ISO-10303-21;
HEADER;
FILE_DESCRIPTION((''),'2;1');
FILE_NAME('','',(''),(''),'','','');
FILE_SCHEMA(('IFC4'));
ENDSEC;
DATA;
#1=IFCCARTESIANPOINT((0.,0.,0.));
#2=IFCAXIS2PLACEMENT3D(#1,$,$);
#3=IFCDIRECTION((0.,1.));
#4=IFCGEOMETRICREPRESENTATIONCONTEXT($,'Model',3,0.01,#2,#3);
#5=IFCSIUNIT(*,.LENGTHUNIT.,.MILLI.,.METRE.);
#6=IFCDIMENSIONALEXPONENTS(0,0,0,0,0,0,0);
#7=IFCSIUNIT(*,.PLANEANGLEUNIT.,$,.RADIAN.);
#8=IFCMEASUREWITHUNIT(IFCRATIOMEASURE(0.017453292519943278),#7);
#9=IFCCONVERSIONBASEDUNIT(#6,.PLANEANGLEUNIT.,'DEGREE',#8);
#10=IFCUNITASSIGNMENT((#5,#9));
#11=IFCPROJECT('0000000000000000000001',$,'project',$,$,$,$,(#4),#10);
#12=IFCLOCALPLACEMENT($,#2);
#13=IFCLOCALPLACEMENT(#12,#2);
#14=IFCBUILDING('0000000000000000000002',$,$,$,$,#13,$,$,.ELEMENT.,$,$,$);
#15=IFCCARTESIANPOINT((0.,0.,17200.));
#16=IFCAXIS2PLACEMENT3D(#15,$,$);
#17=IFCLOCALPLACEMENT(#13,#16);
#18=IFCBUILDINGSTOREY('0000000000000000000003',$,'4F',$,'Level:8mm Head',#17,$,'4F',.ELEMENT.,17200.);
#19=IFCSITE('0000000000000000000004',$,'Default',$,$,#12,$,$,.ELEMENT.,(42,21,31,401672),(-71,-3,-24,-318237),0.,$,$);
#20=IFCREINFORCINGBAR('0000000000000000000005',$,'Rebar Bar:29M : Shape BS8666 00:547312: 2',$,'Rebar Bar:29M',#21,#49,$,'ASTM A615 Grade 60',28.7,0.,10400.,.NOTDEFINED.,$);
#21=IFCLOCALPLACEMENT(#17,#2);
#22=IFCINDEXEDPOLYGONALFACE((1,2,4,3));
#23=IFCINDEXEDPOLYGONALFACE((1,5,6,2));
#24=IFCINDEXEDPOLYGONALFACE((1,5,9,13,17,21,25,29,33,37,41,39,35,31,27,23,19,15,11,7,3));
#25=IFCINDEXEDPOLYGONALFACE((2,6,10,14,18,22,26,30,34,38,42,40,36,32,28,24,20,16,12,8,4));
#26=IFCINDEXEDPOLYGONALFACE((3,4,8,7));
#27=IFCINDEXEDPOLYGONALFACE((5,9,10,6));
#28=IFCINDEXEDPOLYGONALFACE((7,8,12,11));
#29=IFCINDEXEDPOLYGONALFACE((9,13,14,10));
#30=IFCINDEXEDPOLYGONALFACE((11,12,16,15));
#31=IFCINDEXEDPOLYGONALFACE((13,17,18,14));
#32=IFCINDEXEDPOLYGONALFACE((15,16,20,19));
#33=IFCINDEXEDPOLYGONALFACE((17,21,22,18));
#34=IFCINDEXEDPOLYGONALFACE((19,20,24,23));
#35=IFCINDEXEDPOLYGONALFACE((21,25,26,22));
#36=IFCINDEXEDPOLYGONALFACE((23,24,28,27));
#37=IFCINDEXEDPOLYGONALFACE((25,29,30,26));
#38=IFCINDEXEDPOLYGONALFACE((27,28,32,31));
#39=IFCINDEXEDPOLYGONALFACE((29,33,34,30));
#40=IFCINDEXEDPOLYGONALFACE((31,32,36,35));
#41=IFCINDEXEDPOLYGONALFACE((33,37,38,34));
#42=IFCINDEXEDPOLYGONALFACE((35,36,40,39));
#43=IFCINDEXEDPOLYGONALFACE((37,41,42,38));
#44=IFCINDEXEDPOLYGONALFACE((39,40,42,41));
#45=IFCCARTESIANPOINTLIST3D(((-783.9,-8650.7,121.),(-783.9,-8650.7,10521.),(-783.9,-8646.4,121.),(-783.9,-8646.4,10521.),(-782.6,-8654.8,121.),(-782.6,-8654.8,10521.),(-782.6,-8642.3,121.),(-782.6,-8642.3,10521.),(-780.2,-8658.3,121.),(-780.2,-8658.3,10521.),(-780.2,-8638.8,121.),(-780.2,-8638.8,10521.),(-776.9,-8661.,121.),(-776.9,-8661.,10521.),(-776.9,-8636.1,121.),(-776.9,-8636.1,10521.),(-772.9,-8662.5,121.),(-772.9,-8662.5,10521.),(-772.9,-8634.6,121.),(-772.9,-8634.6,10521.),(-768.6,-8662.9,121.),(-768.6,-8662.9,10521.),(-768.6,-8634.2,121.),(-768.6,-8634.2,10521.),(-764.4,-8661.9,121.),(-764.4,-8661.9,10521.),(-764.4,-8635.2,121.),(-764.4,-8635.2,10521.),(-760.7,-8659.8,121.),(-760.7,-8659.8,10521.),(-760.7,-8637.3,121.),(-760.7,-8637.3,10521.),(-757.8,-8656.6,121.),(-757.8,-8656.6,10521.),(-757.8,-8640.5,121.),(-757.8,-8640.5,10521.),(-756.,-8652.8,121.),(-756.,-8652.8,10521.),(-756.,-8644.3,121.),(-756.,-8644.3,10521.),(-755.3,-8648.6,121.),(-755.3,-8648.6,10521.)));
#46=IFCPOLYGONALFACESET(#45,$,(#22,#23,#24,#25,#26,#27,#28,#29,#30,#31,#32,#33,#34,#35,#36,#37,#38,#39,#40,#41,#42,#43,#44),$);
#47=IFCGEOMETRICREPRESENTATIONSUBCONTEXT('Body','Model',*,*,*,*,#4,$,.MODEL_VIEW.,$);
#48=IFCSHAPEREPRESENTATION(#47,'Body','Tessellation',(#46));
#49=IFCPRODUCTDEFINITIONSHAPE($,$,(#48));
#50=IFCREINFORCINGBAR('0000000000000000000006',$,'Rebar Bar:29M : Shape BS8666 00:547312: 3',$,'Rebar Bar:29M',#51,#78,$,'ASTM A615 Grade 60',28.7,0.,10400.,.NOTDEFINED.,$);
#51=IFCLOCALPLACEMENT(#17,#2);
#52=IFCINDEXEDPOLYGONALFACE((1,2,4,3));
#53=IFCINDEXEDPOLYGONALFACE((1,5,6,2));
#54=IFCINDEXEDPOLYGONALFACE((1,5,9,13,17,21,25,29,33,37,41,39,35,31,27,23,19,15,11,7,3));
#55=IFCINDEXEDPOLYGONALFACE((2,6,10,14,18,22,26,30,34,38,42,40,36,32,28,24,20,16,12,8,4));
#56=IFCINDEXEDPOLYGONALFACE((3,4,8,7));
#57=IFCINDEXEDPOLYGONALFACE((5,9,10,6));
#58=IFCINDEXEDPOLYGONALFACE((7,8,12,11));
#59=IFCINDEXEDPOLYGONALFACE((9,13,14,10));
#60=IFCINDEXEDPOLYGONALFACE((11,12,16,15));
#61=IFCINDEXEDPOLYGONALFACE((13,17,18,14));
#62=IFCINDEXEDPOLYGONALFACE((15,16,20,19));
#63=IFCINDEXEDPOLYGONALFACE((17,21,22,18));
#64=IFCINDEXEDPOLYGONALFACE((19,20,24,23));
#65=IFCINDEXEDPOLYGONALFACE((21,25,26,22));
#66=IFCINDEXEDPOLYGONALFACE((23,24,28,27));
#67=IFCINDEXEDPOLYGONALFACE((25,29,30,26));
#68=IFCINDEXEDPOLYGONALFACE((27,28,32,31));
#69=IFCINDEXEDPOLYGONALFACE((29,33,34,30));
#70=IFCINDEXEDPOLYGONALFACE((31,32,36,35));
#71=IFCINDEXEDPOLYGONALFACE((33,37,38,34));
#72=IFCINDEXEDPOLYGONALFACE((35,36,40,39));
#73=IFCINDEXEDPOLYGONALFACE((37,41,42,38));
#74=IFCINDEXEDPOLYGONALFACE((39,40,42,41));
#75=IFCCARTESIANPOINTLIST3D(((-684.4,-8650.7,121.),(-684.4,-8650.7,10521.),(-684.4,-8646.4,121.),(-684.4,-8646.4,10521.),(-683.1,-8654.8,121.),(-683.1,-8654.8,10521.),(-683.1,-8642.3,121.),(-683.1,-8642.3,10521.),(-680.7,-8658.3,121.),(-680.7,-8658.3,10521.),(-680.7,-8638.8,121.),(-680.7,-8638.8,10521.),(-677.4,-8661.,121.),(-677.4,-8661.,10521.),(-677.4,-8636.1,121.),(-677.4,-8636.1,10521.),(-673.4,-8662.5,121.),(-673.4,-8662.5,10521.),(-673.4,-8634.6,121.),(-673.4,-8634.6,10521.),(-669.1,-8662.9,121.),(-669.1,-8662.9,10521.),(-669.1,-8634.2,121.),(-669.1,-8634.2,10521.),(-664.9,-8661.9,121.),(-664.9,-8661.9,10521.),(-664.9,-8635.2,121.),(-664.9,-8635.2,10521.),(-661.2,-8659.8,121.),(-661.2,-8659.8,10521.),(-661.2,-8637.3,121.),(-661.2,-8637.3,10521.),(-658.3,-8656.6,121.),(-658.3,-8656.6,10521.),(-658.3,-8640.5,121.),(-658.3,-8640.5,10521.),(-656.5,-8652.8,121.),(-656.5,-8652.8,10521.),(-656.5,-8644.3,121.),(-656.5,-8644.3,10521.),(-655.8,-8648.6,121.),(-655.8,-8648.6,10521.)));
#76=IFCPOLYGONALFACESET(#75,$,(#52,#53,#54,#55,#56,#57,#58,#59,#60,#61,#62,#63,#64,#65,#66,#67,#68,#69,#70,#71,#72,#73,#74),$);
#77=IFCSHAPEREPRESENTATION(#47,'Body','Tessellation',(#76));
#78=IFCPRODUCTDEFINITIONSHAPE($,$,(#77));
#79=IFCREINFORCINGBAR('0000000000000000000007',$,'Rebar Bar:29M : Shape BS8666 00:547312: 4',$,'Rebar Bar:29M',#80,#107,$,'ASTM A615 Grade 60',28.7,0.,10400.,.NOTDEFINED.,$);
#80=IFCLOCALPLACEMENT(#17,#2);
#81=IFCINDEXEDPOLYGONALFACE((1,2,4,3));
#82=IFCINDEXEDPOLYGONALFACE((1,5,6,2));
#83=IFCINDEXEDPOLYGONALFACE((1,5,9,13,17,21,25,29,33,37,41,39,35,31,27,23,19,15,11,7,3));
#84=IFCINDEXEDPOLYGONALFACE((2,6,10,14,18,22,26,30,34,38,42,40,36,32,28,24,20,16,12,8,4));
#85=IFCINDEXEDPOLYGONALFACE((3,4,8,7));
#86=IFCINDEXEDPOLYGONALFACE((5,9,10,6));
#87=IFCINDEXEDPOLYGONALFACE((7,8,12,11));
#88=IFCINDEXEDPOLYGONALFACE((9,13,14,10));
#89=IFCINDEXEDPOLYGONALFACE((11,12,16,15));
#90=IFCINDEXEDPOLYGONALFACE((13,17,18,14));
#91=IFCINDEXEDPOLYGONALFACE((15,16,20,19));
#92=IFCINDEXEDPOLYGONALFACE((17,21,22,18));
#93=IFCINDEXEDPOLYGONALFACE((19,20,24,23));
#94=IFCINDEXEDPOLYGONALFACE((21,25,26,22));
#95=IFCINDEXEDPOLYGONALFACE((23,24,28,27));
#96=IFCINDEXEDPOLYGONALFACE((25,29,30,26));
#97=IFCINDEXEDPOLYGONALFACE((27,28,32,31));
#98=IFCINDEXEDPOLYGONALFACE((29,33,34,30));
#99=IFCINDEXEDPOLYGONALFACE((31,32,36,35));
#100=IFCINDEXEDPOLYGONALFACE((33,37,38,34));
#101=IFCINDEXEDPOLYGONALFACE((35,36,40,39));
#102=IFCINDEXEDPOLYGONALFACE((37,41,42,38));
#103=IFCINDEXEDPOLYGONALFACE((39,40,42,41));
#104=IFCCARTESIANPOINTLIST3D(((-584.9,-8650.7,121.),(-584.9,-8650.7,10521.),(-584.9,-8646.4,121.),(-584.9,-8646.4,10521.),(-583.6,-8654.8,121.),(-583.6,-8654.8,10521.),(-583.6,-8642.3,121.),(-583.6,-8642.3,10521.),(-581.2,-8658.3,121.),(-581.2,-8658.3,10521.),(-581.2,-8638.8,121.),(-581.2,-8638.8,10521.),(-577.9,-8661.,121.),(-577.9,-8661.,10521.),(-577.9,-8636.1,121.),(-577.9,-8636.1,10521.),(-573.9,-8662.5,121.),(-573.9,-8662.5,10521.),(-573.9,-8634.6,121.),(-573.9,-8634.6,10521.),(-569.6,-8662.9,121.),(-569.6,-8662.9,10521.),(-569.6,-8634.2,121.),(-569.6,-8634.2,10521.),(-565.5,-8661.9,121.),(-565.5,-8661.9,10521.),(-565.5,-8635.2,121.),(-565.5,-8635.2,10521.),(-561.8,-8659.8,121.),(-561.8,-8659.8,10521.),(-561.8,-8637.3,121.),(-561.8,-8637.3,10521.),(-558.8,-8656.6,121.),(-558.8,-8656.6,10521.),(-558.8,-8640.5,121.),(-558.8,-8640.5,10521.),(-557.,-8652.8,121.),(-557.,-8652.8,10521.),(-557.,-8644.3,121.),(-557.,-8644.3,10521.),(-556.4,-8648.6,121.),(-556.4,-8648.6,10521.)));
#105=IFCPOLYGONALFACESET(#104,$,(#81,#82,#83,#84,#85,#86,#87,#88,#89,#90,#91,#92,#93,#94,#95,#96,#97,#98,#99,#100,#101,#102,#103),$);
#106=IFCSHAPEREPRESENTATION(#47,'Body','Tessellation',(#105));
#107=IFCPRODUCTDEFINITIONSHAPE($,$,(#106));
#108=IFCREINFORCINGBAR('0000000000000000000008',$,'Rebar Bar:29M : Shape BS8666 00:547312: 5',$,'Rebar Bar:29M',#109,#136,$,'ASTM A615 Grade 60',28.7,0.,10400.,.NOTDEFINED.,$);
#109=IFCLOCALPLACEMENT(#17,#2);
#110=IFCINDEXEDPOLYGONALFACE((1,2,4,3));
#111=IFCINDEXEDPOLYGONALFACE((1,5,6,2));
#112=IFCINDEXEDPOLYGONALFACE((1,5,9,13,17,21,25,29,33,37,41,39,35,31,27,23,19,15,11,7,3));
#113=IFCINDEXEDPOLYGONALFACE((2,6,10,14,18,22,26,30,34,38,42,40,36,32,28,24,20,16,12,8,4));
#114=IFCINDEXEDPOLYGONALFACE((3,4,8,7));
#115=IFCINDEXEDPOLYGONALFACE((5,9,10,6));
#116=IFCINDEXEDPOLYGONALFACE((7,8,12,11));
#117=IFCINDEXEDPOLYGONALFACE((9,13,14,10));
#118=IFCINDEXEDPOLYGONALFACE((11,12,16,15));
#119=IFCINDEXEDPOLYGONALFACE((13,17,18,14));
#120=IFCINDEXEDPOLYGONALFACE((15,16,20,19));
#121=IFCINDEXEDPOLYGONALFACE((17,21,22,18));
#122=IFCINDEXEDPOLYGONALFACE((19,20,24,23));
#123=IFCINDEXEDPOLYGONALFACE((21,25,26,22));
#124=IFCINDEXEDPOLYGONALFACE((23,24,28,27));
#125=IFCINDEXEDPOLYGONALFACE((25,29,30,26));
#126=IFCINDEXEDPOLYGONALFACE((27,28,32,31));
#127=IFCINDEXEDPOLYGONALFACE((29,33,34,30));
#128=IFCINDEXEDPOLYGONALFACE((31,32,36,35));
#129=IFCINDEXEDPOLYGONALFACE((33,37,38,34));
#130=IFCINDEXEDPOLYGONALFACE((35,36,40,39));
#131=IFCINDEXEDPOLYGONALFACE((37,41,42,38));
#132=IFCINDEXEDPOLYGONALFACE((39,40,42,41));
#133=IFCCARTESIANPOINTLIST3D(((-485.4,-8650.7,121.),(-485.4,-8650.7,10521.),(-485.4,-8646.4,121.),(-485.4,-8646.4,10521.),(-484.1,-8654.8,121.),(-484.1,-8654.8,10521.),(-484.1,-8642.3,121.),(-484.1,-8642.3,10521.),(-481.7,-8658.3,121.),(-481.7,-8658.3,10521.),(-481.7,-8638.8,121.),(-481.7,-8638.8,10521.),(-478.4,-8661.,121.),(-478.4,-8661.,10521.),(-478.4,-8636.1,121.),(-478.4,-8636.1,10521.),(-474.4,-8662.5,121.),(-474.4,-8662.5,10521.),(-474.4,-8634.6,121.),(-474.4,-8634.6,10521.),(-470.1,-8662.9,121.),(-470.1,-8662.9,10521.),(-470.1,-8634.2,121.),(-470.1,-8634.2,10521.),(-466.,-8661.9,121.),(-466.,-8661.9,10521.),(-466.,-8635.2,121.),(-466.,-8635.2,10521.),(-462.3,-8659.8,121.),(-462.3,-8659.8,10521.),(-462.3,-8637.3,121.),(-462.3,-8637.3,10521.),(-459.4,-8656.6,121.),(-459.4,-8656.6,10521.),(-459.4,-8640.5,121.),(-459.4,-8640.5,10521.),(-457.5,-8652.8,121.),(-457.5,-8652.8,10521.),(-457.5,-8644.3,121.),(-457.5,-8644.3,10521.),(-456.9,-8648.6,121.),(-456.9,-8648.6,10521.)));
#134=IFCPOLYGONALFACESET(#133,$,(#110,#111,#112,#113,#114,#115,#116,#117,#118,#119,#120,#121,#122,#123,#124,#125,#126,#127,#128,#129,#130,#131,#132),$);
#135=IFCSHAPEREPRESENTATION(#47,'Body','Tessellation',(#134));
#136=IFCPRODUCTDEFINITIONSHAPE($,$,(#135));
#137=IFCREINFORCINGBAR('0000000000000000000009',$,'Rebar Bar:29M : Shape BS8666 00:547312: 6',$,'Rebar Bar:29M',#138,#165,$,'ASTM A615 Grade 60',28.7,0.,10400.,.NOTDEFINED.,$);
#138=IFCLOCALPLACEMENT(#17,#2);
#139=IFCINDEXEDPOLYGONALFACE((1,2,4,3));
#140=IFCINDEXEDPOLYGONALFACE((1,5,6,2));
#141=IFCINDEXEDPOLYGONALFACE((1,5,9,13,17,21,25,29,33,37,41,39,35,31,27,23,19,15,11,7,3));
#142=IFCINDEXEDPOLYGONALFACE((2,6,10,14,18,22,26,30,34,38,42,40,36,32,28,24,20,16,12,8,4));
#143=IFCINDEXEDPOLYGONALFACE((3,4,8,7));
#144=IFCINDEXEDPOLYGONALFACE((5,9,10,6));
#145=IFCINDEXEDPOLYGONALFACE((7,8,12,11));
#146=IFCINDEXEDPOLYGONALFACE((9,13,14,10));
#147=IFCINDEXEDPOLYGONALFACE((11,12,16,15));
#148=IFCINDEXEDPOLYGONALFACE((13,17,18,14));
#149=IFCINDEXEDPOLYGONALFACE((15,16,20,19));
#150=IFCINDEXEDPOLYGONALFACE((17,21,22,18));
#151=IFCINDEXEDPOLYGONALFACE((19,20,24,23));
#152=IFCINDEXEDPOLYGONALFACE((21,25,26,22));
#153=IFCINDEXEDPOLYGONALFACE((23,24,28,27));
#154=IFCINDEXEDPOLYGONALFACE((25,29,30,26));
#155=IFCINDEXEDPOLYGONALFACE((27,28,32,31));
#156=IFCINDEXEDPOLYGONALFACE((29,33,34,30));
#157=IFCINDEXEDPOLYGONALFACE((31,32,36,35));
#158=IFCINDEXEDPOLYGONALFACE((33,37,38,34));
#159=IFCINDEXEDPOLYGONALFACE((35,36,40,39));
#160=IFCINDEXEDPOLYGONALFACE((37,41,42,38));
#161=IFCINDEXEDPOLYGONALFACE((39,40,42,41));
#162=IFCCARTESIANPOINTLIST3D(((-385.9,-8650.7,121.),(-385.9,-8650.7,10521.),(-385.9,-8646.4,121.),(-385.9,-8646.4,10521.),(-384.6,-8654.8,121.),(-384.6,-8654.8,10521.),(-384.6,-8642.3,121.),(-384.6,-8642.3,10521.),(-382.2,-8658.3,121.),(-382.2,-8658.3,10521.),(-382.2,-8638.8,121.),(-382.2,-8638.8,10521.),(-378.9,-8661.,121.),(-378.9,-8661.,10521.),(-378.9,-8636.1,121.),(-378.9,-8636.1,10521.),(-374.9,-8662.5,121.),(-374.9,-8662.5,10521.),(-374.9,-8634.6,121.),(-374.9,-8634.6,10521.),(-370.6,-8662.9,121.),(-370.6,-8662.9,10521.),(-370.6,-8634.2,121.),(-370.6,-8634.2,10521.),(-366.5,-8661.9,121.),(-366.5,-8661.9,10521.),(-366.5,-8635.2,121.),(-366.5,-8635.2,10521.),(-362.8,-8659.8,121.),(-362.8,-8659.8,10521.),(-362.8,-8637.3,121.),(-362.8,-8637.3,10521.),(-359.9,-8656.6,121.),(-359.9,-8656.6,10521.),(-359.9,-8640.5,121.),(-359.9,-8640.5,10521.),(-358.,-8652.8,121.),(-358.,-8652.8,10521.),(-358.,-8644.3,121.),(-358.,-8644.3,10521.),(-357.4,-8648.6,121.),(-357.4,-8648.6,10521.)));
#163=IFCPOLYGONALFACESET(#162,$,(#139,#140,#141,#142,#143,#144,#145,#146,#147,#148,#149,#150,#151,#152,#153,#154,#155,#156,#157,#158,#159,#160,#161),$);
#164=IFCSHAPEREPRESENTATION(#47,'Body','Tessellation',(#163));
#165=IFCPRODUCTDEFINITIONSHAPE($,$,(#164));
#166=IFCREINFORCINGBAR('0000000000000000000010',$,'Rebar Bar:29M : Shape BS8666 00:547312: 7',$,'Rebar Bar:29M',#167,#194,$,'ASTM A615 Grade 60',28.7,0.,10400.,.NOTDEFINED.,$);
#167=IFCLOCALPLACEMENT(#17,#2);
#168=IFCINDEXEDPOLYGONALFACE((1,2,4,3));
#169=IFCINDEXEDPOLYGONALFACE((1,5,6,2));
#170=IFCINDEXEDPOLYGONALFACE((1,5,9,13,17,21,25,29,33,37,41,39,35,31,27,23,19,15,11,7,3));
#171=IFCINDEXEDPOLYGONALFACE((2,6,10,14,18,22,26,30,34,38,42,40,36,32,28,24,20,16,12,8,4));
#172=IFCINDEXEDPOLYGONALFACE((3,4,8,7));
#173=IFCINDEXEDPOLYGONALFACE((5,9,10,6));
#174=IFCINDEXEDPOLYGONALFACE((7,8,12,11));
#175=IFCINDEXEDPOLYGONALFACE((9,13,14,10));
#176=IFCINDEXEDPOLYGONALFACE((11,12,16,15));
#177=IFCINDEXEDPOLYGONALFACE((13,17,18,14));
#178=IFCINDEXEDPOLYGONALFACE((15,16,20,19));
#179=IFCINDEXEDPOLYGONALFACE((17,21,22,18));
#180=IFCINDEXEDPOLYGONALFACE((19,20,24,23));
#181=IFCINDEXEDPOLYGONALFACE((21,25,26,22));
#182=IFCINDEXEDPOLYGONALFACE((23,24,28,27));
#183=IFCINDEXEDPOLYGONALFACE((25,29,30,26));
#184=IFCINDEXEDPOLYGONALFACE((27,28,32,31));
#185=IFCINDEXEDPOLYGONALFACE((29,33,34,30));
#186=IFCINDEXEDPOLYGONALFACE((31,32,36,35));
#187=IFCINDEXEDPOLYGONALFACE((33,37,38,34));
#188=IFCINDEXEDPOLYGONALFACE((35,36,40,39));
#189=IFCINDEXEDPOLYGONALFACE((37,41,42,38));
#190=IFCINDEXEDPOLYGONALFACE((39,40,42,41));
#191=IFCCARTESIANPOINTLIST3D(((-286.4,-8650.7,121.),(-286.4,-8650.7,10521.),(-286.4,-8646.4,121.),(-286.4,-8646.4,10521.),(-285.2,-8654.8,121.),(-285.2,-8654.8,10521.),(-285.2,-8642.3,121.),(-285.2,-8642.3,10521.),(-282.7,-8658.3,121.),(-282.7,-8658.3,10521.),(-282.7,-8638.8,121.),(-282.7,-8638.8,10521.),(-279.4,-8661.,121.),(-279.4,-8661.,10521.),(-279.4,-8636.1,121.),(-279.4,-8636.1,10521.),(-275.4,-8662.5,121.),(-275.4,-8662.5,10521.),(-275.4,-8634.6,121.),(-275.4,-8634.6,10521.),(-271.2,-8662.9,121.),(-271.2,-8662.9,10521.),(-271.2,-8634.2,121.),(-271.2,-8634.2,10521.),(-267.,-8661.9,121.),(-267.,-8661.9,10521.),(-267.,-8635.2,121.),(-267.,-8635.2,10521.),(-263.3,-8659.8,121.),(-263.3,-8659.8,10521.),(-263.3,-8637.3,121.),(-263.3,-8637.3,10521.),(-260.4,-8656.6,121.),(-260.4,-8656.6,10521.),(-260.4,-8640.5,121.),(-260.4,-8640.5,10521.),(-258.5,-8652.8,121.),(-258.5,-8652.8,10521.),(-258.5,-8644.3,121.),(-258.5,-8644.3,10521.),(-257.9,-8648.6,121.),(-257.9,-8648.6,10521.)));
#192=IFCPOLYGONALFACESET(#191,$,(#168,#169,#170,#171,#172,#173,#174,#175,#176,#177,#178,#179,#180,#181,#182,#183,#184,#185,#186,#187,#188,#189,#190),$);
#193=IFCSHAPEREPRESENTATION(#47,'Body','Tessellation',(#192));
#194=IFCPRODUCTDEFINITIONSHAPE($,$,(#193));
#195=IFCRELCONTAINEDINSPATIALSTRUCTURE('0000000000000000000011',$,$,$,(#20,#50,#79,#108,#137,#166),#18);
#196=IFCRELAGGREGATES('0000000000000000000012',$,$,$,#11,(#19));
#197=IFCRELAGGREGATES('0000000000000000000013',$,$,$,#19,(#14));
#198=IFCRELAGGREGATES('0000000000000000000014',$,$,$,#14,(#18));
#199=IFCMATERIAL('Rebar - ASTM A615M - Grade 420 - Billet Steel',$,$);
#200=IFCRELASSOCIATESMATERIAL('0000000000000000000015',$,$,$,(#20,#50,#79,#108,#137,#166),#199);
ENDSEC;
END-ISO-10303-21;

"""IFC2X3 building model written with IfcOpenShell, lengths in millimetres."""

from ifc_helpers import new_model, entity, si_unit, converted_unit, direction, frame, origin, place, context, subcontext, project, spatial, material, element, save


model = new_model("IFC2X3")

# Units and contexts
model_context = context("Model", 3, precision=0.01, world=origin(), true_north=direction((0.0, 1.0)))
body_context = subcontext(model_context, "Body", "Model", "MODEL_VIEW")
ifc_project = project(units=[si_unit("LENGTHUNIT", "METRE", prefix="MILLI"), converted_unit("PLANEANGLEUNIT", "DEGREE", entity("IfcRatioMeasure", 0.017453292519943278), si_unit("PLANEANGLEUNIT", "RADIAN"), dimensions=[0, 0, 0, 0, 0, 0, 0])], contexts=[model_context])

# Site, building, storey
site_placement = place(None, origin())
site = spatial("IfcSite", under=ifc_project, at=site_placement, Name="Default", CompositionType="ELEMENT", RefLatitude=(42, 21, 31, 401672), RefLongitude=(-71, -3, -24, -318237), RefElevation=0.0)
building_placement = place(site_placement, origin())
building = spatial("IfcBuilding", under=site, at=building_placement, CompositionType="ELEMENT")
storey_placement = place(building_placement, frame((0.0, 0.0, 17200.0)))
storey = spatial("IfcBuildingStorey", under=building, at=storey_placement, Name="4F", ObjectType="Level:8mm Head", LongName="4F", CompositionType="ELEMENT", Elevation=17200.0)

# Reinforcing bars
ifc_material_1 = material(Name="Rebar - ASTM A615M - Grade 420 - Billet Steel")
reinforcing_bar_1_placement = place(storey_placement, origin())
element("IfcReinforcingBar", 1, at=reinforcing_bar_1_placement, inside=storey, material=ifc_material_1, Name="Rebar Bar:29M : Shape BS8666 00:547312: 2", SteelGrade="ASTM A615 Grade 60", ObjectType="Rebar Bar:29M", BarLength=10400.0, BarRole="NOTDEFINED", CrossSectionArea=0.0, NominalDiameter=28.7, context=body_context, shape_type="AdvancedSweptSolid", body=[
    entity("IfcSweptDiskSolid", entity("IfcCompositeCurve", [entity("IfcCompositeCurveSegment", "CONTINUOUS", True, entity("IfcPolyline", [entity("IfcCartesianPoint", [-769.7, -8648.6, 121.0]), entity("IfcCartesianPoint", [-769.7, -8648.6, 10521.0])]))], False), 14.3, None, 0.0, 1.0),
])
reinforcing_bar_2_placement = place(storey_placement, origin())
element("IfcReinforcingBar", 2, at=reinforcing_bar_2_placement, inside=storey, material=ifc_material_1, Name="Rebar Bar:29M : Shape BS8666 00:547312: 3", SteelGrade="ASTM A615 Grade 60", ObjectType="Rebar Bar:29M", BarLength=10400.0, BarRole="NOTDEFINED", CrossSectionArea=0.0, NominalDiameter=28.7, context=body_context, shape_type="AdvancedSweptSolid", body=[
    entity("IfcSweptDiskSolid", entity("IfcCompositeCurve", [entity("IfcCompositeCurveSegment", "CONTINUOUS", True, entity("IfcPolyline", [entity("IfcCartesianPoint", [-670.2, -8648.6, 121.0]), entity("IfcCartesianPoint", [-670.2, -8648.6, 10521.0])]))], False), 14.3, None, 0.0, 1.0),
])
reinforcing_bar_3_placement = place(storey_placement, origin())
element("IfcReinforcingBar", 3, at=reinforcing_bar_3_placement, inside=storey, material=ifc_material_1, Name="Rebar Bar:29M : Shape BS8666 00:547312: 4", SteelGrade="ASTM A615 Grade 60", ObjectType="Rebar Bar:29M", BarLength=10400.0, BarRole="NOTDEFINED", CrossSectionArea=0.0, NominalDiameter=28.7, context=body_context, shape_type="AdvancedSweptSolid", body=[
    entity("IfcSweptDiskSolid", entity("IfcCompositeCurve", [entity("IfcCompositeCurveSegment", "CONTINUOUS", True, entity("IfcPolyline", [entity("IfcCartesianPoint", [-570.7, -8648.6, 121.0]), entity("IfcCartesianPoint", [-570.7, -8648.6, 10521.0])]))], False), 14.3, None, 0.0, 1.0),
])
reinforcing_bar_4_placement = place(storey_placement, origin())
element("IfcReinforcingBar", 4, at=reinforcing_bar_4_placement, inside=storey, material=ifc_material_1, Name="Rebar Bar:29M : Shape BS8666 00:547312: 5", SteelGrade="ASTM A615 Grade 60", ObjectType="Rebar Bar:29M", BarLength=10400.0, BarRole="NOTDEFINED", CrossSectionArea=0.0, NominalDiameter=28.7, context=body_context, shape_type="AdvancedSweptSolid", body=[
    entity("IfcSweptDiskSolid", entity("IfcCompositeCurve", [entity("IfcCompositeCurveSegment", "CONTINUOUS", True, entity("IfcPolyline", [entity("IfcCartesianPoint", [-471.2, -8648.6, 121.0]), entity("IfcCartesianPoint", [-471.2, -8648.6, 10521.0])]))], False), 14.3, None, 0.0, 1.0),
])
reinforcing_bar_5_placement = place(storey_placement, origin())
element("IfcReinforcingBar", 5, at=reinforcing_bar_5_placement, inside=storey, material=ifc_material_1, Name="Rebar Bar:29M : Shape BS8666 00:547312: 6", SteelGrade="ASTM A615 Grade 60", ObjectType="Rebar Bar:29M", BarLength=10400.0, BarRole="NOTDEFINED", CrossSectionArea=0.0, NominalDiameter=28.7, context=body_context, shape_type="AdvancedSweptSolid", body=[
    entity("IfcSweptDiskSolid", entity("IfcCompositeCurve", [entity("IfcCompositeCurveSegment", "CONTINUOUS", True, entity("IfcPolyline", [entity("IfcCartesianPoint", [-371.7, -8648.6, 121.0]), entity("IfcCartesianPoint", [-371.7, -8648.6, 10521.0])]))], False), 14.3, None, 0.0, 1.0),
])
reinforcing_bar_6_placement = place(storey_placement, origin())
element("IfcReinforcingBar", 6, at=reinforcing_bar_6_placement, inside=storey, material=ifc_material_1, Name="Rebar Bar:29M : Shape BS8666 00:547312: 7", SteelGrade="ASTM A615 Grade 60", ObjectType="Rebar Bar:29M", BarLength=10400.0, BarRole="NOTDEFINED", CrossSectionArea=0.0, NominalDiameter=28.7, context=body_context, shape_type="AdvancedSweptSolid", body=[
    entity("IfcSweptDiskSolid", entity("IfcCompositeCurve", [entity("IfcCompositeCurveSegment", "CONTINUOUS", True, entity("IfcPolyline", [entity("IfcCartesianPoint", [-272.2, -8648.6, 121.0]), entity("IfcCartesianPoint", [-272.2, -8648.6, 10521.0])]))], False), 14.3, None, 0.0, 1.0),
])

save(model, "model.ifc")
